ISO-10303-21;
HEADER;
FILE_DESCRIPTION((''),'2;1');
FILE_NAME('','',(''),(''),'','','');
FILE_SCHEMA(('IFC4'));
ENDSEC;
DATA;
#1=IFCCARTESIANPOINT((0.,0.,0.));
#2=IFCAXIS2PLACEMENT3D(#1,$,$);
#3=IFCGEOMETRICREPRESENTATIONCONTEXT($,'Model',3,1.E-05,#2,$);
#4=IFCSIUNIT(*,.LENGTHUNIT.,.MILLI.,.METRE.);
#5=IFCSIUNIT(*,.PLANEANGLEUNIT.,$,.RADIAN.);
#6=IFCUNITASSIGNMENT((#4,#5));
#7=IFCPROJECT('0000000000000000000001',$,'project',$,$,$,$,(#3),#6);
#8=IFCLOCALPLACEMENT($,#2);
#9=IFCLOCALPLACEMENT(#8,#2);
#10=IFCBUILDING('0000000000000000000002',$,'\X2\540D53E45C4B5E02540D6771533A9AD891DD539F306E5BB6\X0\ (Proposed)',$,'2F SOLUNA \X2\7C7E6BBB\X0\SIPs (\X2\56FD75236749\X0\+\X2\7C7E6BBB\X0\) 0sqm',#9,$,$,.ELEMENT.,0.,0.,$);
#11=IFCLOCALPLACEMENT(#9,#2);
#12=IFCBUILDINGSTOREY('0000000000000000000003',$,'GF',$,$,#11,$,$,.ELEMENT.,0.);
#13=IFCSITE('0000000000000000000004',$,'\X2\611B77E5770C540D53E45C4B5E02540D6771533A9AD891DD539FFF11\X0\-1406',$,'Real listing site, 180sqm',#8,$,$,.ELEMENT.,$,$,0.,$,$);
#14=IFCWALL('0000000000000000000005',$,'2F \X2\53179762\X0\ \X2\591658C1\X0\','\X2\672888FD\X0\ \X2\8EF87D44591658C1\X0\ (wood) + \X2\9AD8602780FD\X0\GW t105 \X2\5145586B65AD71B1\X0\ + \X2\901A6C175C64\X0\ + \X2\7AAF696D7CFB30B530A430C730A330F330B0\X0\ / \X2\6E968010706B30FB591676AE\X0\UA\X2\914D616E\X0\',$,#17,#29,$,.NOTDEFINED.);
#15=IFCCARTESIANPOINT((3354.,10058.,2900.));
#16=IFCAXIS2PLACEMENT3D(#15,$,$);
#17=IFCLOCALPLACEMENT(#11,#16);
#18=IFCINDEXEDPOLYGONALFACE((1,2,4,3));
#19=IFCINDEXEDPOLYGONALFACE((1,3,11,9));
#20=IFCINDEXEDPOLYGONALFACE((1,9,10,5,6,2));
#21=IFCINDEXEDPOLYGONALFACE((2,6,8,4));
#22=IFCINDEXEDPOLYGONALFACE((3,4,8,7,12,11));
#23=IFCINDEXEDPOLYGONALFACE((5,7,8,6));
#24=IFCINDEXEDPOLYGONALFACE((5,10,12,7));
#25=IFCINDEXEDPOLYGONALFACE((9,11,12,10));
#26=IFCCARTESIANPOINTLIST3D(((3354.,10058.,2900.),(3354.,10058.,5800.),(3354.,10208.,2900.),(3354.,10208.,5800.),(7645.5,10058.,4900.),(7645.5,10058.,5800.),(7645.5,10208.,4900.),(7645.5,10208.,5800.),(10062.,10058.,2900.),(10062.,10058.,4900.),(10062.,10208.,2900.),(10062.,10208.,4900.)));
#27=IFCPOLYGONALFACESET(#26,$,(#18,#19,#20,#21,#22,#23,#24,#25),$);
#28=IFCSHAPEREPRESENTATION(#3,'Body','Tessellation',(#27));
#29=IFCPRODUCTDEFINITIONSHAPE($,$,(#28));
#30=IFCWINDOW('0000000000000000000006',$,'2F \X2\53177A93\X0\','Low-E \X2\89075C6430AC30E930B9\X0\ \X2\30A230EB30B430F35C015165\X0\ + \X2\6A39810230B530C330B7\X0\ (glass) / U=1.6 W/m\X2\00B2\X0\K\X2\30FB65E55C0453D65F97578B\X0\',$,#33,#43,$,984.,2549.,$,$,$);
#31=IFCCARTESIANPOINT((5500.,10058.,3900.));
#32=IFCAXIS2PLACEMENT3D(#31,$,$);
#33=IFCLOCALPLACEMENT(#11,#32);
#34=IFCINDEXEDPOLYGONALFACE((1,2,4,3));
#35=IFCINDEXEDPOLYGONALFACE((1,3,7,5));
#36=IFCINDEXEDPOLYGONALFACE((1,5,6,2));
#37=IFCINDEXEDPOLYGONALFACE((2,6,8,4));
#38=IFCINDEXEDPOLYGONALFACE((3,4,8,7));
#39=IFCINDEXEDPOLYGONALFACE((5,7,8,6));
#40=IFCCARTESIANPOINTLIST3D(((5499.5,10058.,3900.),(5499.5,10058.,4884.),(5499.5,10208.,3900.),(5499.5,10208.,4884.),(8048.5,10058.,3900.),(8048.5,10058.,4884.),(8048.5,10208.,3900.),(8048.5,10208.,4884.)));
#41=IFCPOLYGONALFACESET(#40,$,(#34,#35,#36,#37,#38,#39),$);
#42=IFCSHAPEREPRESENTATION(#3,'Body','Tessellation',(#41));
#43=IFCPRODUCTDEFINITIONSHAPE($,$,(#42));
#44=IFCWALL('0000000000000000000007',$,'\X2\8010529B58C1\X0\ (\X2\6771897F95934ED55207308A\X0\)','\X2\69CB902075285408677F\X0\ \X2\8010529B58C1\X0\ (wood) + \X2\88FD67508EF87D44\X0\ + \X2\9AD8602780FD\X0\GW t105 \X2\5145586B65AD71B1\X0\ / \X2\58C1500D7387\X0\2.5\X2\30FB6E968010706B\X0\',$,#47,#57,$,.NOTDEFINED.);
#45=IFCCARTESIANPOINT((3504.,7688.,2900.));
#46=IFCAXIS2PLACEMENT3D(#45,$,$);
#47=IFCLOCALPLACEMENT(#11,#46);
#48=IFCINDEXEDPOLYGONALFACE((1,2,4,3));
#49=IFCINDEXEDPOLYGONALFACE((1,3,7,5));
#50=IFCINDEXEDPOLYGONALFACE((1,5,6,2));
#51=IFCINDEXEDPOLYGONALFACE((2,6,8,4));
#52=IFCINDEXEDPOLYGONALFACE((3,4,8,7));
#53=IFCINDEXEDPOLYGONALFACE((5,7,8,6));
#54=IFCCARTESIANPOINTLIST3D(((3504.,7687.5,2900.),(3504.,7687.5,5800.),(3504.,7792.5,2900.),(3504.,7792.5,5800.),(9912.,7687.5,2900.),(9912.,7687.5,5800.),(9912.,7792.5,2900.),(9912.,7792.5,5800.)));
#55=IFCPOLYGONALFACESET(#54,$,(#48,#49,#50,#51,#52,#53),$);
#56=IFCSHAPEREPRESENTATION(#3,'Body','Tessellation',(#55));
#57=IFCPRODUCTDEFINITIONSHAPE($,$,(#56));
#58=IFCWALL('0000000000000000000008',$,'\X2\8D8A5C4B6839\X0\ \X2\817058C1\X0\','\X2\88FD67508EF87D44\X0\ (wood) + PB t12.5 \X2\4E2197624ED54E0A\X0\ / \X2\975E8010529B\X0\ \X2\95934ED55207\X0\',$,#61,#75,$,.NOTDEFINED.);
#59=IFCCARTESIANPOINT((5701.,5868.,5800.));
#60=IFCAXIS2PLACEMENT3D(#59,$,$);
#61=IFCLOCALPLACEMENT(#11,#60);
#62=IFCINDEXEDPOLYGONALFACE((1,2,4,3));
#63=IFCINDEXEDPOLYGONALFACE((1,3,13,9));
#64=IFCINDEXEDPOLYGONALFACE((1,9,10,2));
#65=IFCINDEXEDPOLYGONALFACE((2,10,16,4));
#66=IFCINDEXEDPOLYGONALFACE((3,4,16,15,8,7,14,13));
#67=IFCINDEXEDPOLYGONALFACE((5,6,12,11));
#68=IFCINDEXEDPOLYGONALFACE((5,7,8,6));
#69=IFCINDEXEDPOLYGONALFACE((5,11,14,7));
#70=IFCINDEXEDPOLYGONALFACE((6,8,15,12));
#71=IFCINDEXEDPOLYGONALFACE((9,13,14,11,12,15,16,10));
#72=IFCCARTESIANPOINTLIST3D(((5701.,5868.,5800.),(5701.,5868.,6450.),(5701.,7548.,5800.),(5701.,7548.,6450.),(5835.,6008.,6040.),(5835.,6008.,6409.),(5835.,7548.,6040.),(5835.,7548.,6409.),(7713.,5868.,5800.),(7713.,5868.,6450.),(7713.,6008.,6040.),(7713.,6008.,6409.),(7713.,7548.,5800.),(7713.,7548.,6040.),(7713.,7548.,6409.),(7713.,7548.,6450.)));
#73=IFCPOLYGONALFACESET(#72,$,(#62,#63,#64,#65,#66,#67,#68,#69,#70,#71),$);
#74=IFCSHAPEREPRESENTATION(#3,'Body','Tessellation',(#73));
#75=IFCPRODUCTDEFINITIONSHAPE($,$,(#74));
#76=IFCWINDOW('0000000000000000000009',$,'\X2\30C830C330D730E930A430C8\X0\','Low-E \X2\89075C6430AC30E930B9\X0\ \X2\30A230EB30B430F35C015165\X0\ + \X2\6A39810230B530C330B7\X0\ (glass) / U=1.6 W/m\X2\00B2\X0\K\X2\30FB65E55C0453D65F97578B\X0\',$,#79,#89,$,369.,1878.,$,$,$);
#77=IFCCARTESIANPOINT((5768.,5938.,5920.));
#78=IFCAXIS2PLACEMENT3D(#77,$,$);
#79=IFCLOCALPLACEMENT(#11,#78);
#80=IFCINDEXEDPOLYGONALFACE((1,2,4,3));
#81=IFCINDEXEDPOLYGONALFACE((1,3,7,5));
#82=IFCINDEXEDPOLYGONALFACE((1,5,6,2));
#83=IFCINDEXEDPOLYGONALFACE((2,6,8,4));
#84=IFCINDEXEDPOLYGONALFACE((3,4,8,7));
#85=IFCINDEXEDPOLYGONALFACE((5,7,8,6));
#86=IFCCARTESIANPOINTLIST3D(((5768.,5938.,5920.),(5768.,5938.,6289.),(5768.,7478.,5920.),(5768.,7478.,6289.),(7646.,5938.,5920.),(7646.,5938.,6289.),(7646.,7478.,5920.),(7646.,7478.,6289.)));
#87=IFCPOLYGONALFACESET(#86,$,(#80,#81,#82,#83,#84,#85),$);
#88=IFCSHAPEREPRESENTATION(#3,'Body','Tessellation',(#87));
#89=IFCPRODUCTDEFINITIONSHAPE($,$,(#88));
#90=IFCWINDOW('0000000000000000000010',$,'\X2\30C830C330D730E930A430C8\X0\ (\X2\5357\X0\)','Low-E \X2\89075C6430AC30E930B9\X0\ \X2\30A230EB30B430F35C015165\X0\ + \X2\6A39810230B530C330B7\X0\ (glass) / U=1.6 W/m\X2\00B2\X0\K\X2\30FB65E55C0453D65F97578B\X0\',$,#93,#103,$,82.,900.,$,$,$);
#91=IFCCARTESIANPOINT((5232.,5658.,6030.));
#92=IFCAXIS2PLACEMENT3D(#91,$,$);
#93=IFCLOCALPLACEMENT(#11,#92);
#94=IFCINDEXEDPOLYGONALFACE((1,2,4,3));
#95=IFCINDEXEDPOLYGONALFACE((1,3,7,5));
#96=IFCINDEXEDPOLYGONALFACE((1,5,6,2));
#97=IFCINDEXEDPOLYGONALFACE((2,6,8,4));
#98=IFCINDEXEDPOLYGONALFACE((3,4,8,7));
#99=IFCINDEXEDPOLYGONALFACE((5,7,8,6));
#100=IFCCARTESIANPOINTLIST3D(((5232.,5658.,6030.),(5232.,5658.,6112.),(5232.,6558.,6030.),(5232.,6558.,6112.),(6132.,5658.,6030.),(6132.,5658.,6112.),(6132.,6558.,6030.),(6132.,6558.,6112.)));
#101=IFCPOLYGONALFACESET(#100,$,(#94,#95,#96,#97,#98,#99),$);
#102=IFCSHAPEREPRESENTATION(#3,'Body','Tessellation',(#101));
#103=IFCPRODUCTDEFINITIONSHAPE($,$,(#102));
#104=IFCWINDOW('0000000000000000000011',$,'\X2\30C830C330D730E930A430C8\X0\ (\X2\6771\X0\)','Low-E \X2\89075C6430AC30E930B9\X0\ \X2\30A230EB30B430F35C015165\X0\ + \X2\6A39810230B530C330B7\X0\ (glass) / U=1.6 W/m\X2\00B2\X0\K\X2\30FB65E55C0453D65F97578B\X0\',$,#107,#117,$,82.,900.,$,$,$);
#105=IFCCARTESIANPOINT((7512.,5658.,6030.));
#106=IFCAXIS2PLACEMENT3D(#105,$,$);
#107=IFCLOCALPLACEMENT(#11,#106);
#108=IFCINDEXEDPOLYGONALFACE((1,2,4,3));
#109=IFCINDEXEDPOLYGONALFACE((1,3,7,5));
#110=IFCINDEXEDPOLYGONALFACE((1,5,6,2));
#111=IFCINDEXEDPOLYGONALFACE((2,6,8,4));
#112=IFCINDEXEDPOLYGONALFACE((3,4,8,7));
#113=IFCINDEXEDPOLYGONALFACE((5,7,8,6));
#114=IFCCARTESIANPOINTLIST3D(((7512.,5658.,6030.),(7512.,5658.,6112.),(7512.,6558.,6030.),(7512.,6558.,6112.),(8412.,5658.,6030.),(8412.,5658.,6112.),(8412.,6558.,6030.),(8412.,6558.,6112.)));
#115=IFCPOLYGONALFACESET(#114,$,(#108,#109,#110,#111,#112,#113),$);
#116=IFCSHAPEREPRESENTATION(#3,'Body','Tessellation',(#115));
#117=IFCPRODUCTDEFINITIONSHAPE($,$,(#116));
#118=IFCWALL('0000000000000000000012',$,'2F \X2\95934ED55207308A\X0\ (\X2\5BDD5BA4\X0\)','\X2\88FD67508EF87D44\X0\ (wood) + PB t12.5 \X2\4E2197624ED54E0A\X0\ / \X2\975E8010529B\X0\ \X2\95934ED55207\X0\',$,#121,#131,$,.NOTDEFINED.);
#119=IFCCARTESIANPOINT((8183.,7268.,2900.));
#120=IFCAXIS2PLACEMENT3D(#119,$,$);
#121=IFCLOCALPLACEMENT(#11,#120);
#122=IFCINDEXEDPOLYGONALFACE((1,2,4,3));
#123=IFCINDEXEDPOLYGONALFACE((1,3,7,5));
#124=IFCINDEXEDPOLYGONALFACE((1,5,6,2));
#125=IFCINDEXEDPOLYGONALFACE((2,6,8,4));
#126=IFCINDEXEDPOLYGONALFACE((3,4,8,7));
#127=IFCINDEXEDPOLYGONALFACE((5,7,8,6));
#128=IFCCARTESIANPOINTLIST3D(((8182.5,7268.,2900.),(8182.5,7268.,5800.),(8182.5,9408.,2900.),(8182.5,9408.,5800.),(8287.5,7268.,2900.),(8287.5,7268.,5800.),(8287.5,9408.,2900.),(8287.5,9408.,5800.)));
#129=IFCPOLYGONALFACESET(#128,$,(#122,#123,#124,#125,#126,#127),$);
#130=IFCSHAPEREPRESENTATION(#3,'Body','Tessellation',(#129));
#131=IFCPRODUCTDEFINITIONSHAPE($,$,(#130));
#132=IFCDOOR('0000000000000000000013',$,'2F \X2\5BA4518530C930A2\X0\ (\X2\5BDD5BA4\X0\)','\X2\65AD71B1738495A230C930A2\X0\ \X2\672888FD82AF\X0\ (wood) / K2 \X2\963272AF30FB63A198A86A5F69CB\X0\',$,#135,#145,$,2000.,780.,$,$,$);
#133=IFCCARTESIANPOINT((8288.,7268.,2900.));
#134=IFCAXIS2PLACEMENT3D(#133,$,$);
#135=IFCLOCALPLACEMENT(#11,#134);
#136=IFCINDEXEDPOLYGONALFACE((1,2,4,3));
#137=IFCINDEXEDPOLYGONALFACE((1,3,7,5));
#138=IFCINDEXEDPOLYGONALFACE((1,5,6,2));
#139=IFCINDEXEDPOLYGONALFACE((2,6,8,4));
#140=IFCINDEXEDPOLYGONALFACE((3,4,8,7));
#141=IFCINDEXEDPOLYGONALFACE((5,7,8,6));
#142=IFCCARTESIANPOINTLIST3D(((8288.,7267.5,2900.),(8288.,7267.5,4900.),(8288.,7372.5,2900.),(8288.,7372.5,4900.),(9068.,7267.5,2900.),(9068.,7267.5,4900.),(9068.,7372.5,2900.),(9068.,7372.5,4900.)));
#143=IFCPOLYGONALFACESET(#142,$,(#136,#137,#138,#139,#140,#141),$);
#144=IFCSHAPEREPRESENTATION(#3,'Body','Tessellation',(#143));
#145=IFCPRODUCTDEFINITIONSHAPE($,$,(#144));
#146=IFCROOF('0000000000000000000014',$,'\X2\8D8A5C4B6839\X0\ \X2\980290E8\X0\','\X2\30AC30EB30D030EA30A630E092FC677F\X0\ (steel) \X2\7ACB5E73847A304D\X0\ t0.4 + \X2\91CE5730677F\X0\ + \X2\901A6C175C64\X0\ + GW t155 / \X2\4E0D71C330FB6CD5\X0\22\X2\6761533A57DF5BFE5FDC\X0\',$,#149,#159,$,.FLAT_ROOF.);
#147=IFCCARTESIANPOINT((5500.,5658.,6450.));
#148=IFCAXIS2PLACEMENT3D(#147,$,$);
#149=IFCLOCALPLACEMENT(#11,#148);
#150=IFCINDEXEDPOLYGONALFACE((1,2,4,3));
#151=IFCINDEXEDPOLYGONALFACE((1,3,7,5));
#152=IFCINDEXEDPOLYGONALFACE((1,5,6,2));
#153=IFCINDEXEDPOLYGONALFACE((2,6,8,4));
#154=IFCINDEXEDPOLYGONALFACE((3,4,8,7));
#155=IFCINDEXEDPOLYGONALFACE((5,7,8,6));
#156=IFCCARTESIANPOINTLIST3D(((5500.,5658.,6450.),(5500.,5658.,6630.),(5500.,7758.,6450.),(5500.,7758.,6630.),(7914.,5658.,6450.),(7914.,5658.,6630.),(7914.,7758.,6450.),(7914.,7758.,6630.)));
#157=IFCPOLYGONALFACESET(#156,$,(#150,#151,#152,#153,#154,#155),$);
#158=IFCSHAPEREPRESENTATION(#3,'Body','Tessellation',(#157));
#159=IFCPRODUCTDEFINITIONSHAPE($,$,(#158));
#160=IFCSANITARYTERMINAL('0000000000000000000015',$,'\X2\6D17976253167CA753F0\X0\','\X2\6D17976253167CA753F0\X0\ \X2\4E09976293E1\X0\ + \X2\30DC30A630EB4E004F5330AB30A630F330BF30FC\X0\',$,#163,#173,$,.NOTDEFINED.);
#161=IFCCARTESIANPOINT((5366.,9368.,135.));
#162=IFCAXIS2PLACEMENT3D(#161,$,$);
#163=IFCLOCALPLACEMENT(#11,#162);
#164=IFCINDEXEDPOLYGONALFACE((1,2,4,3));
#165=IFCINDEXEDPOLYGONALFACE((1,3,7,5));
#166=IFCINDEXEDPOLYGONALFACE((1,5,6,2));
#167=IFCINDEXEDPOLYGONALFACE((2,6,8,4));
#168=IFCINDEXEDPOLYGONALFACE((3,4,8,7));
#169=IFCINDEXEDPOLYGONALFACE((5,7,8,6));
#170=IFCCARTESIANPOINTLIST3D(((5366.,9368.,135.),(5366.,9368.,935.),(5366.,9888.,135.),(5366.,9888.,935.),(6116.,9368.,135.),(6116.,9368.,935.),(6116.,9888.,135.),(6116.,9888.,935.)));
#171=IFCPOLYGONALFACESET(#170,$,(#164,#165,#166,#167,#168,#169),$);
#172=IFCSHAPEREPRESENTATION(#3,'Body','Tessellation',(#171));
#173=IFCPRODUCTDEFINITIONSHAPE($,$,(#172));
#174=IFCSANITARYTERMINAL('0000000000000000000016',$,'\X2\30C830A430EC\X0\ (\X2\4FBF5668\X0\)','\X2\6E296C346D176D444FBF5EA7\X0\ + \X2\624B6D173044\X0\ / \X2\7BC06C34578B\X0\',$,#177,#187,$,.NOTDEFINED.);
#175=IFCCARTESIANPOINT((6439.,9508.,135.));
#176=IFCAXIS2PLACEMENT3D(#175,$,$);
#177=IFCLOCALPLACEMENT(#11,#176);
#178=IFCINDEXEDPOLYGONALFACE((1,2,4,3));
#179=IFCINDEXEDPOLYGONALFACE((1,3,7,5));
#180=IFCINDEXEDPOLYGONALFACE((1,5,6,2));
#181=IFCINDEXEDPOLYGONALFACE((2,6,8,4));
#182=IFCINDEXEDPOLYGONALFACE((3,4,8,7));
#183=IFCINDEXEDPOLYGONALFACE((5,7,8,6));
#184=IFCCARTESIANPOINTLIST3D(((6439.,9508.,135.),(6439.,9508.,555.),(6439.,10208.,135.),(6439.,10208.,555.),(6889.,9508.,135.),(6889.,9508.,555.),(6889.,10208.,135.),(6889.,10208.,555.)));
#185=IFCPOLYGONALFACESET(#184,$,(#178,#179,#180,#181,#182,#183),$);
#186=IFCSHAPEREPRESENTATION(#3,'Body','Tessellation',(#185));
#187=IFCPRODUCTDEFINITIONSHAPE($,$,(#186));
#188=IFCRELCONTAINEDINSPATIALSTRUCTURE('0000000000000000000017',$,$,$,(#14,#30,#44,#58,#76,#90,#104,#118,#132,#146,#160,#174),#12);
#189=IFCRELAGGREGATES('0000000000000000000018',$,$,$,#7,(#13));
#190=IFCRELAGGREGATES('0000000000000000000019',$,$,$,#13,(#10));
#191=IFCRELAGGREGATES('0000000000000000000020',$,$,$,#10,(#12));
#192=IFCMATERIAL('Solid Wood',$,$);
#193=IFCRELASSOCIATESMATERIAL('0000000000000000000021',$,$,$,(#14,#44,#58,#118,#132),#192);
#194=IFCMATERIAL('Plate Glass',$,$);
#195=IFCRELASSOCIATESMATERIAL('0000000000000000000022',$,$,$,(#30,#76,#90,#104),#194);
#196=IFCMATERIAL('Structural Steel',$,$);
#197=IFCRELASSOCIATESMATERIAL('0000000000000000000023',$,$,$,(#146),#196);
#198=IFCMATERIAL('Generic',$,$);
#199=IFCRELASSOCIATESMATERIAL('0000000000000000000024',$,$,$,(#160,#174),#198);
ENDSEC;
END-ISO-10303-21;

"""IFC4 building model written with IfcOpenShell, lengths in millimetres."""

from ifc_helpers import new_model, si_unit, frame, frame_2d, origin, place, context, project, spatial, rectangle, extrude, material, element, fill, save


model = new_model("IFC4")

# Units and contexts
model_context = context("Model", 3, precision=1e-05, world=origin())
ifc_project = project(units=[si_unit("LENGTHUNIT", "METRE", prefix="MILLI"), si_unit("PLANEANGLEUNIT", "RADIAN")], contexts=[model_context])

# Site, building, storey
site_placement = place(None, origin())
site = spatial("IfcSite", under=ifc_project, at=site_placement, Name="愛知県名古屋市名東区高針原１-1406", ObjectType="Real listing site, 180sqm", CompositionType="ELEMENT", RefElevation=0.0)
building_placement = place(site_placement, origin())
building = spatial("IfcBuilding", under=site, at=building_placement, Name="名古屋市名東区高針原の家 (Proposed)", ObjectType="2F SOLUNA 籾殻SIPs (国産杉+籾殻) 0sqm", CompositionType="ELEMENT", ElevationOfRefHeight=0.0, ElevationOfTerrain=0.0)
storey_placement = place(building_placement, origin())
storey = spatial("IfcBuildingStorey", under=building, at=storey_placement, Name="GF", CompositionType="ELEMENT", Elevation=0.0)

# Wall, opening, window
ifc_material_1 = material(Name="Solid Wood")
wall_1_placement = place(storey_placement, frame((3354.0, 10058.0, 2900.0)))
wall_1 = element("IfcWall", 1, at=wall_1_placement, inside=storey, material=ifc_material_1, Name="2F 北面 外壁", Description="木製 軸組外壁 (wood) + 高性能GW t105 充填断熱 + 通気層 + 窯業系サイディング / 準耐火・外皮UA配慮", PredefinedType="NOTDEFINED", context=model_context, shape_type="SweptSolid", body=[
    extrude(rectangle(XDim=6708.0, YDim=150.0, at=frame_2d((3354.0, 75.0))), frame((3354.0, 10058.0, 2900.0)), (0.0, 0.0, 1.0), 2900.0),
])
opening_1_placement = place(storey_placement, frame((5500.0, 10058.0, 3900.0)))
opening_1 = element("IfcOpeningElement", 2, at=opening_1_placement, cuts=wall_1, PredefinedType="NOTDEFINED", context=model_context, shape_type="SweptSolid", body=[
    extrude(rectangle(XDim=2549.0, YDim=150.0, at=frame_2d((1274.0, 75.0))), frame((5500.0, 10058.0, 3900.0)), (0.0, 0.0, 1.0), 984.0),
])
ifc_material_2 = material(Name="Plate Glass")
window_1_placement = place(storey_placement, frame((5500.0, 10058.0, 3900.0)))
window_1 = element("IfcWindow", 3, at=window_1_placement, inside=storey, material=ifc_material_2, Name="2F 北窓", Description="Low-E 複層ガラス アルゴン封入 + 樹脂サッシ (glass) / U=1.6 W/m²K・日射取得型", OverallHeight=984.0, OverallWidth=2549.0, context=model_context, shape_type="SweptSolid", body=[
    extrude(rectangle(XDim=2549.0, YDim=150.0, at=frame_2d((1274.0, 75.0))), frame((5500.0, 10058.0, 3900.0)), (0.0, 0.0, 1.0), 984.0),
])
fill(opening_1, window_1)

# Wall
wall_2_placement = place(storey_placement, frame((3504.0, 7688.0, 2900.0)))
element("IfcWall", 4, at=wall_2_placement, inside=storey, material=ifc_material_1, Name="耐力壁 (東西間仕切り)", Description="構造用合板 耐力壁 (wood) + 製材軸組 + 高性能GW t105 充填断熱 / 壁倍率2.5・準耐火", PredefinedType="NOTDEFINED", context=model_context, shape_type="SweptSolid", body=[
    extrude(rectangle(XDim=6408.0, YDim=105.0, at=frame_2d((3204.0, 52.0))), frame((3504.0, 7688.0, 2900.0)), (0.0, 0.0, 1.0), 2900.0),
])

# Wall, openings, windows
wall_3_placement = place(storey_placement, frame((5701.0, 5868.0, 5800.0)))
wall_3 = element("IfcWall", 5, at=wall_3_placement, inside=storey, material=ifc_material_1, Name="越屋根 腰壁", Description="製材軸組 (wood) + PB t12.5 両面仕上 / 非耐力 間仕切", PredefinedType="NOTDEFINED", context=model_context, shape_type="SweptSolid", body=[
    extrude(rectangle(XDim=2012.0, YDim=1680.0, at=frame_2d((1006.0, 840.0))), frame((5701.0, 5868.0, 5800.0)), (0.0, 0.0, 1.0), 650.0),
])
opening_2_placement = place(storey_placement, frame((5768.0, 5938.0, 5920.0)))
opening_2 = element("IfcOpeningElement", 6, at=opening_2_placement, cuts=wall_3, PredefinedType="NOTDEFINED", context=model_context, shape_type="SweptSolid", body=[
    extrude(rectangle(XDim=1878.0, YDim=1540.0, at=frame_2d((939.0, 770.0))), frame((5768.0, 5938.0, 5920.0)), (0.0, 0.0, 1.0), 369.0),
])
opening_3_placement = place(storey_placement, frame((5232.0, 5658.0, 6030.0)))
opening_3 = element("IfcOpeningElement", 7, at=opening_3_placement, cuts=wall_3, PredefinedType="NOTDEFINED", context=model_context, shape_type="SweptSolid", body=[
    extrude(rectangle(XDim=900.0, YDim=900.0, at=frame_2d((450.0, 450.0))), frame((5232.0, 5658.0, 6030.0)), (0.0, 0.0, 1.0), 82.0),
])
opening_4_placement = place(storey_placement, frame((7512.0, 5658.0, 6030.0)))
opening_4 = element("IfcOpeningElement", 8, at=opening_4_placement, cuts=wall_3, PredefinedType="NOTDEFINED", context=model_context, shape_type="SweptSolid", body=[
    extrude(rectangle(XDim=900.0, YDim=900.0, at=frame_2d((450.0, 450.0))), frame((7512.0, 5658.0, 6030.0)), (0.0, 0.0, 1.0), 82.0),
])
window_2_placement = place(storey_placement, frame((5768.0, 5938.0, 5920.0)))
window_2 = element("IfcWindow", 9, at=window_2_placement, inside=storey, material=ifc_material_2, Name="トップライト", Description="Low-E 複層ガラス アルゴン封入 + 樹脂サッシ (glass) / U=1.6 W/m²K・日射取得型", OverallHeight=369.0, OverallWidth=1878.0, context=model_context, shape_type="SweptSolid", body=[
    extrude(rectangle(XDim=1878.0, YDim=1540.0, at=frame_2d((939.0, 770.0))), frame((5768.0, 5938.0, 5920.0)), (0.0, 0.0, 1.0), 369.0),
])
fill(opening_2, window_2)
window_3_placement = place(storey_placement, frame((5232.0, 5658.0, 6030.0)))
window_3 = element("IfcWindow", 10, at=window_3_placement, inside=storey, material=ifc_material_2, Name="トップライト (南)", Description="Low-E 複層ガラス アルゴン封入 + 樹脂サッシ (glass) / U=1.6 W/m²K・日射取得型", OverallHeight=82.0, OverallWidth=900.0, context=model_context, shape_type="SweptSolid", body=[
    extrude(rectangle(XDim=900.0, YDim=900.0, at=frame_2d((450.0, 450.0))), frame((5232.0, 5658.0, 6030.0)), (0.0, 0.0, 1.0), 82.0),
])
fill(opening_3, window_3)
window_4_placement = place(storey_placement, frame((7512.0, 5658.0, 6030.0)))
window_4 = element("IfcWindow", 11, at=window_4_placement, inside=storey, material=ifc_material_2, Name="トップライト (東)", Description="Low-E 複層ガラス アルゴン封入 + 樹脂サッシ (glass) / U=1.6 W/m²K・日射取得型", OverallHeight=82.0, OverallWidth=900.0, context=model_context, shape_type="SweptSolid", body=[
    extrude(rectangle(XDim=900.0, YDim=900.0, at=frame_2d((450.0, 450.0))), frame((7512.0, 5658.0, 6030.0)), (0.0, 0.0, 1.0), 82.0),
])
fill(opening_4, window_4)

# Wall
wall_4_placement = place(storey_placement, frame((8183.0, 7268.0, 2900.0)))
element("IfcWall", 12, at=wall_4_placement, inside=storey, material=ifc_material_1, Name="2F 間仕切り (寝室)", Description="製材軸組 (wood) + PB t12.5 両面仕上 / 非耐力 間仕切", PredefinedType="NOTDEFINED", context=model_context, shape_type="SweptSolid", body=[
    extrude(rectangle(XDim=105.0, YDim=2140.0, at=frame_2d((52.0, 1070.0))), frame((8183.0, 7268.0, 2900.0)), (0.0, 0.0, 1.0), 2900.0),
])

# Door
door_placement = place(storey_placement, frame((8288.0, 7268.0, 2900.0)))
element("IfcDoor", 13, at=door_placement, inside=storey, material=ifc_material_1, Name="2F 室内ドア (寝室)", Description="断熱玄関ドア 木製芯 (wood) / K2 防犯・採風機構", OverallHeight=2000.0, OverallWidth=780.0, context=model_context, shape_type="SweptSolid", body=[
    extrude(rectangle(XDim=780.0, YDim=105.0, at=frame_2d((390.0, 52.0))), frame((8288.0, 7268.0, 2900.0)), (0.0, 0.0, 1.0), 2000.0),
])

# Roof
ifc_material_3 = material(Name="Structural Steel")
roof_placement = place(storey_placement, frame((5500.0, 5658.0, 6450.0)))
element("IfcRoof", 14, at=roof_placement, inside=storey, material=ifc_material_3, Name="越屋根 頂部", Description="ガルバリウム鋼板 (steel) 立平葺き t0.4 + 野地板 + 通気層 + GW t155 / 不燃・法22条区域対応", PredefinedType="FLAT_ROOF", context=model_context, shape_type="SweptSolid", body=[
    extrude(rectangle(XDim=2414.0, YDim=2100.0, at=frame_2d((1207.0, 1050.0))), frame((5500.0, 5658.0, 6450.0)), (0.0, 0.0, 1.0), 180.0),
])

# Sanitary terminals
ifc_material_4 = material(Name="Generic")
sanitary_terminal_1_placement = place(storey_placement, frame((5366.0, 9368.0, 135.0)))
element("IfcSanitaryTerminal", 15, at=sanitary_terminal_1_placement, inside=storey, material=ifc_material_4, Name="洗面化粧台", Description="洗面化粧台 三面鏡 + ボウル一体カウンター", PredefinedType="NOTDEFINED", context=model_context, shape_type="SweptSolid", body=[
    extrude(rectangle(XDim=750.0, YDim=520.0, at=frame_2d((375.0, 260.0))), frame((5366.0, 9368.0, 135.0)), (0.0, 0.0, 1.0), 800.0),
])
sanitary_terminal_2_placement = place(storey_placement, frame((6439.0, 9508.0, 135.0)))
element("IfcSanitaryTerminal", 16, at=sanitary_terminal_2_placement, inside=storey, material=ifc_material_4, Name="トイレ (便器)", Description="温水洗浄便座 + 手洗い / 節水型", PredefinedType="NOTDEFINED", context=model_context, shape_type="SweptSolid", body=[
    extrude(rectangle(XDim=450.0, YDim=700.0, at=frame_2d((225.0, 350.0))), frame((6439.0, 9508.0, 135.0)), (0.0, 0.0, 1.0), 420.0),
])

save(model, "model.ifc")
